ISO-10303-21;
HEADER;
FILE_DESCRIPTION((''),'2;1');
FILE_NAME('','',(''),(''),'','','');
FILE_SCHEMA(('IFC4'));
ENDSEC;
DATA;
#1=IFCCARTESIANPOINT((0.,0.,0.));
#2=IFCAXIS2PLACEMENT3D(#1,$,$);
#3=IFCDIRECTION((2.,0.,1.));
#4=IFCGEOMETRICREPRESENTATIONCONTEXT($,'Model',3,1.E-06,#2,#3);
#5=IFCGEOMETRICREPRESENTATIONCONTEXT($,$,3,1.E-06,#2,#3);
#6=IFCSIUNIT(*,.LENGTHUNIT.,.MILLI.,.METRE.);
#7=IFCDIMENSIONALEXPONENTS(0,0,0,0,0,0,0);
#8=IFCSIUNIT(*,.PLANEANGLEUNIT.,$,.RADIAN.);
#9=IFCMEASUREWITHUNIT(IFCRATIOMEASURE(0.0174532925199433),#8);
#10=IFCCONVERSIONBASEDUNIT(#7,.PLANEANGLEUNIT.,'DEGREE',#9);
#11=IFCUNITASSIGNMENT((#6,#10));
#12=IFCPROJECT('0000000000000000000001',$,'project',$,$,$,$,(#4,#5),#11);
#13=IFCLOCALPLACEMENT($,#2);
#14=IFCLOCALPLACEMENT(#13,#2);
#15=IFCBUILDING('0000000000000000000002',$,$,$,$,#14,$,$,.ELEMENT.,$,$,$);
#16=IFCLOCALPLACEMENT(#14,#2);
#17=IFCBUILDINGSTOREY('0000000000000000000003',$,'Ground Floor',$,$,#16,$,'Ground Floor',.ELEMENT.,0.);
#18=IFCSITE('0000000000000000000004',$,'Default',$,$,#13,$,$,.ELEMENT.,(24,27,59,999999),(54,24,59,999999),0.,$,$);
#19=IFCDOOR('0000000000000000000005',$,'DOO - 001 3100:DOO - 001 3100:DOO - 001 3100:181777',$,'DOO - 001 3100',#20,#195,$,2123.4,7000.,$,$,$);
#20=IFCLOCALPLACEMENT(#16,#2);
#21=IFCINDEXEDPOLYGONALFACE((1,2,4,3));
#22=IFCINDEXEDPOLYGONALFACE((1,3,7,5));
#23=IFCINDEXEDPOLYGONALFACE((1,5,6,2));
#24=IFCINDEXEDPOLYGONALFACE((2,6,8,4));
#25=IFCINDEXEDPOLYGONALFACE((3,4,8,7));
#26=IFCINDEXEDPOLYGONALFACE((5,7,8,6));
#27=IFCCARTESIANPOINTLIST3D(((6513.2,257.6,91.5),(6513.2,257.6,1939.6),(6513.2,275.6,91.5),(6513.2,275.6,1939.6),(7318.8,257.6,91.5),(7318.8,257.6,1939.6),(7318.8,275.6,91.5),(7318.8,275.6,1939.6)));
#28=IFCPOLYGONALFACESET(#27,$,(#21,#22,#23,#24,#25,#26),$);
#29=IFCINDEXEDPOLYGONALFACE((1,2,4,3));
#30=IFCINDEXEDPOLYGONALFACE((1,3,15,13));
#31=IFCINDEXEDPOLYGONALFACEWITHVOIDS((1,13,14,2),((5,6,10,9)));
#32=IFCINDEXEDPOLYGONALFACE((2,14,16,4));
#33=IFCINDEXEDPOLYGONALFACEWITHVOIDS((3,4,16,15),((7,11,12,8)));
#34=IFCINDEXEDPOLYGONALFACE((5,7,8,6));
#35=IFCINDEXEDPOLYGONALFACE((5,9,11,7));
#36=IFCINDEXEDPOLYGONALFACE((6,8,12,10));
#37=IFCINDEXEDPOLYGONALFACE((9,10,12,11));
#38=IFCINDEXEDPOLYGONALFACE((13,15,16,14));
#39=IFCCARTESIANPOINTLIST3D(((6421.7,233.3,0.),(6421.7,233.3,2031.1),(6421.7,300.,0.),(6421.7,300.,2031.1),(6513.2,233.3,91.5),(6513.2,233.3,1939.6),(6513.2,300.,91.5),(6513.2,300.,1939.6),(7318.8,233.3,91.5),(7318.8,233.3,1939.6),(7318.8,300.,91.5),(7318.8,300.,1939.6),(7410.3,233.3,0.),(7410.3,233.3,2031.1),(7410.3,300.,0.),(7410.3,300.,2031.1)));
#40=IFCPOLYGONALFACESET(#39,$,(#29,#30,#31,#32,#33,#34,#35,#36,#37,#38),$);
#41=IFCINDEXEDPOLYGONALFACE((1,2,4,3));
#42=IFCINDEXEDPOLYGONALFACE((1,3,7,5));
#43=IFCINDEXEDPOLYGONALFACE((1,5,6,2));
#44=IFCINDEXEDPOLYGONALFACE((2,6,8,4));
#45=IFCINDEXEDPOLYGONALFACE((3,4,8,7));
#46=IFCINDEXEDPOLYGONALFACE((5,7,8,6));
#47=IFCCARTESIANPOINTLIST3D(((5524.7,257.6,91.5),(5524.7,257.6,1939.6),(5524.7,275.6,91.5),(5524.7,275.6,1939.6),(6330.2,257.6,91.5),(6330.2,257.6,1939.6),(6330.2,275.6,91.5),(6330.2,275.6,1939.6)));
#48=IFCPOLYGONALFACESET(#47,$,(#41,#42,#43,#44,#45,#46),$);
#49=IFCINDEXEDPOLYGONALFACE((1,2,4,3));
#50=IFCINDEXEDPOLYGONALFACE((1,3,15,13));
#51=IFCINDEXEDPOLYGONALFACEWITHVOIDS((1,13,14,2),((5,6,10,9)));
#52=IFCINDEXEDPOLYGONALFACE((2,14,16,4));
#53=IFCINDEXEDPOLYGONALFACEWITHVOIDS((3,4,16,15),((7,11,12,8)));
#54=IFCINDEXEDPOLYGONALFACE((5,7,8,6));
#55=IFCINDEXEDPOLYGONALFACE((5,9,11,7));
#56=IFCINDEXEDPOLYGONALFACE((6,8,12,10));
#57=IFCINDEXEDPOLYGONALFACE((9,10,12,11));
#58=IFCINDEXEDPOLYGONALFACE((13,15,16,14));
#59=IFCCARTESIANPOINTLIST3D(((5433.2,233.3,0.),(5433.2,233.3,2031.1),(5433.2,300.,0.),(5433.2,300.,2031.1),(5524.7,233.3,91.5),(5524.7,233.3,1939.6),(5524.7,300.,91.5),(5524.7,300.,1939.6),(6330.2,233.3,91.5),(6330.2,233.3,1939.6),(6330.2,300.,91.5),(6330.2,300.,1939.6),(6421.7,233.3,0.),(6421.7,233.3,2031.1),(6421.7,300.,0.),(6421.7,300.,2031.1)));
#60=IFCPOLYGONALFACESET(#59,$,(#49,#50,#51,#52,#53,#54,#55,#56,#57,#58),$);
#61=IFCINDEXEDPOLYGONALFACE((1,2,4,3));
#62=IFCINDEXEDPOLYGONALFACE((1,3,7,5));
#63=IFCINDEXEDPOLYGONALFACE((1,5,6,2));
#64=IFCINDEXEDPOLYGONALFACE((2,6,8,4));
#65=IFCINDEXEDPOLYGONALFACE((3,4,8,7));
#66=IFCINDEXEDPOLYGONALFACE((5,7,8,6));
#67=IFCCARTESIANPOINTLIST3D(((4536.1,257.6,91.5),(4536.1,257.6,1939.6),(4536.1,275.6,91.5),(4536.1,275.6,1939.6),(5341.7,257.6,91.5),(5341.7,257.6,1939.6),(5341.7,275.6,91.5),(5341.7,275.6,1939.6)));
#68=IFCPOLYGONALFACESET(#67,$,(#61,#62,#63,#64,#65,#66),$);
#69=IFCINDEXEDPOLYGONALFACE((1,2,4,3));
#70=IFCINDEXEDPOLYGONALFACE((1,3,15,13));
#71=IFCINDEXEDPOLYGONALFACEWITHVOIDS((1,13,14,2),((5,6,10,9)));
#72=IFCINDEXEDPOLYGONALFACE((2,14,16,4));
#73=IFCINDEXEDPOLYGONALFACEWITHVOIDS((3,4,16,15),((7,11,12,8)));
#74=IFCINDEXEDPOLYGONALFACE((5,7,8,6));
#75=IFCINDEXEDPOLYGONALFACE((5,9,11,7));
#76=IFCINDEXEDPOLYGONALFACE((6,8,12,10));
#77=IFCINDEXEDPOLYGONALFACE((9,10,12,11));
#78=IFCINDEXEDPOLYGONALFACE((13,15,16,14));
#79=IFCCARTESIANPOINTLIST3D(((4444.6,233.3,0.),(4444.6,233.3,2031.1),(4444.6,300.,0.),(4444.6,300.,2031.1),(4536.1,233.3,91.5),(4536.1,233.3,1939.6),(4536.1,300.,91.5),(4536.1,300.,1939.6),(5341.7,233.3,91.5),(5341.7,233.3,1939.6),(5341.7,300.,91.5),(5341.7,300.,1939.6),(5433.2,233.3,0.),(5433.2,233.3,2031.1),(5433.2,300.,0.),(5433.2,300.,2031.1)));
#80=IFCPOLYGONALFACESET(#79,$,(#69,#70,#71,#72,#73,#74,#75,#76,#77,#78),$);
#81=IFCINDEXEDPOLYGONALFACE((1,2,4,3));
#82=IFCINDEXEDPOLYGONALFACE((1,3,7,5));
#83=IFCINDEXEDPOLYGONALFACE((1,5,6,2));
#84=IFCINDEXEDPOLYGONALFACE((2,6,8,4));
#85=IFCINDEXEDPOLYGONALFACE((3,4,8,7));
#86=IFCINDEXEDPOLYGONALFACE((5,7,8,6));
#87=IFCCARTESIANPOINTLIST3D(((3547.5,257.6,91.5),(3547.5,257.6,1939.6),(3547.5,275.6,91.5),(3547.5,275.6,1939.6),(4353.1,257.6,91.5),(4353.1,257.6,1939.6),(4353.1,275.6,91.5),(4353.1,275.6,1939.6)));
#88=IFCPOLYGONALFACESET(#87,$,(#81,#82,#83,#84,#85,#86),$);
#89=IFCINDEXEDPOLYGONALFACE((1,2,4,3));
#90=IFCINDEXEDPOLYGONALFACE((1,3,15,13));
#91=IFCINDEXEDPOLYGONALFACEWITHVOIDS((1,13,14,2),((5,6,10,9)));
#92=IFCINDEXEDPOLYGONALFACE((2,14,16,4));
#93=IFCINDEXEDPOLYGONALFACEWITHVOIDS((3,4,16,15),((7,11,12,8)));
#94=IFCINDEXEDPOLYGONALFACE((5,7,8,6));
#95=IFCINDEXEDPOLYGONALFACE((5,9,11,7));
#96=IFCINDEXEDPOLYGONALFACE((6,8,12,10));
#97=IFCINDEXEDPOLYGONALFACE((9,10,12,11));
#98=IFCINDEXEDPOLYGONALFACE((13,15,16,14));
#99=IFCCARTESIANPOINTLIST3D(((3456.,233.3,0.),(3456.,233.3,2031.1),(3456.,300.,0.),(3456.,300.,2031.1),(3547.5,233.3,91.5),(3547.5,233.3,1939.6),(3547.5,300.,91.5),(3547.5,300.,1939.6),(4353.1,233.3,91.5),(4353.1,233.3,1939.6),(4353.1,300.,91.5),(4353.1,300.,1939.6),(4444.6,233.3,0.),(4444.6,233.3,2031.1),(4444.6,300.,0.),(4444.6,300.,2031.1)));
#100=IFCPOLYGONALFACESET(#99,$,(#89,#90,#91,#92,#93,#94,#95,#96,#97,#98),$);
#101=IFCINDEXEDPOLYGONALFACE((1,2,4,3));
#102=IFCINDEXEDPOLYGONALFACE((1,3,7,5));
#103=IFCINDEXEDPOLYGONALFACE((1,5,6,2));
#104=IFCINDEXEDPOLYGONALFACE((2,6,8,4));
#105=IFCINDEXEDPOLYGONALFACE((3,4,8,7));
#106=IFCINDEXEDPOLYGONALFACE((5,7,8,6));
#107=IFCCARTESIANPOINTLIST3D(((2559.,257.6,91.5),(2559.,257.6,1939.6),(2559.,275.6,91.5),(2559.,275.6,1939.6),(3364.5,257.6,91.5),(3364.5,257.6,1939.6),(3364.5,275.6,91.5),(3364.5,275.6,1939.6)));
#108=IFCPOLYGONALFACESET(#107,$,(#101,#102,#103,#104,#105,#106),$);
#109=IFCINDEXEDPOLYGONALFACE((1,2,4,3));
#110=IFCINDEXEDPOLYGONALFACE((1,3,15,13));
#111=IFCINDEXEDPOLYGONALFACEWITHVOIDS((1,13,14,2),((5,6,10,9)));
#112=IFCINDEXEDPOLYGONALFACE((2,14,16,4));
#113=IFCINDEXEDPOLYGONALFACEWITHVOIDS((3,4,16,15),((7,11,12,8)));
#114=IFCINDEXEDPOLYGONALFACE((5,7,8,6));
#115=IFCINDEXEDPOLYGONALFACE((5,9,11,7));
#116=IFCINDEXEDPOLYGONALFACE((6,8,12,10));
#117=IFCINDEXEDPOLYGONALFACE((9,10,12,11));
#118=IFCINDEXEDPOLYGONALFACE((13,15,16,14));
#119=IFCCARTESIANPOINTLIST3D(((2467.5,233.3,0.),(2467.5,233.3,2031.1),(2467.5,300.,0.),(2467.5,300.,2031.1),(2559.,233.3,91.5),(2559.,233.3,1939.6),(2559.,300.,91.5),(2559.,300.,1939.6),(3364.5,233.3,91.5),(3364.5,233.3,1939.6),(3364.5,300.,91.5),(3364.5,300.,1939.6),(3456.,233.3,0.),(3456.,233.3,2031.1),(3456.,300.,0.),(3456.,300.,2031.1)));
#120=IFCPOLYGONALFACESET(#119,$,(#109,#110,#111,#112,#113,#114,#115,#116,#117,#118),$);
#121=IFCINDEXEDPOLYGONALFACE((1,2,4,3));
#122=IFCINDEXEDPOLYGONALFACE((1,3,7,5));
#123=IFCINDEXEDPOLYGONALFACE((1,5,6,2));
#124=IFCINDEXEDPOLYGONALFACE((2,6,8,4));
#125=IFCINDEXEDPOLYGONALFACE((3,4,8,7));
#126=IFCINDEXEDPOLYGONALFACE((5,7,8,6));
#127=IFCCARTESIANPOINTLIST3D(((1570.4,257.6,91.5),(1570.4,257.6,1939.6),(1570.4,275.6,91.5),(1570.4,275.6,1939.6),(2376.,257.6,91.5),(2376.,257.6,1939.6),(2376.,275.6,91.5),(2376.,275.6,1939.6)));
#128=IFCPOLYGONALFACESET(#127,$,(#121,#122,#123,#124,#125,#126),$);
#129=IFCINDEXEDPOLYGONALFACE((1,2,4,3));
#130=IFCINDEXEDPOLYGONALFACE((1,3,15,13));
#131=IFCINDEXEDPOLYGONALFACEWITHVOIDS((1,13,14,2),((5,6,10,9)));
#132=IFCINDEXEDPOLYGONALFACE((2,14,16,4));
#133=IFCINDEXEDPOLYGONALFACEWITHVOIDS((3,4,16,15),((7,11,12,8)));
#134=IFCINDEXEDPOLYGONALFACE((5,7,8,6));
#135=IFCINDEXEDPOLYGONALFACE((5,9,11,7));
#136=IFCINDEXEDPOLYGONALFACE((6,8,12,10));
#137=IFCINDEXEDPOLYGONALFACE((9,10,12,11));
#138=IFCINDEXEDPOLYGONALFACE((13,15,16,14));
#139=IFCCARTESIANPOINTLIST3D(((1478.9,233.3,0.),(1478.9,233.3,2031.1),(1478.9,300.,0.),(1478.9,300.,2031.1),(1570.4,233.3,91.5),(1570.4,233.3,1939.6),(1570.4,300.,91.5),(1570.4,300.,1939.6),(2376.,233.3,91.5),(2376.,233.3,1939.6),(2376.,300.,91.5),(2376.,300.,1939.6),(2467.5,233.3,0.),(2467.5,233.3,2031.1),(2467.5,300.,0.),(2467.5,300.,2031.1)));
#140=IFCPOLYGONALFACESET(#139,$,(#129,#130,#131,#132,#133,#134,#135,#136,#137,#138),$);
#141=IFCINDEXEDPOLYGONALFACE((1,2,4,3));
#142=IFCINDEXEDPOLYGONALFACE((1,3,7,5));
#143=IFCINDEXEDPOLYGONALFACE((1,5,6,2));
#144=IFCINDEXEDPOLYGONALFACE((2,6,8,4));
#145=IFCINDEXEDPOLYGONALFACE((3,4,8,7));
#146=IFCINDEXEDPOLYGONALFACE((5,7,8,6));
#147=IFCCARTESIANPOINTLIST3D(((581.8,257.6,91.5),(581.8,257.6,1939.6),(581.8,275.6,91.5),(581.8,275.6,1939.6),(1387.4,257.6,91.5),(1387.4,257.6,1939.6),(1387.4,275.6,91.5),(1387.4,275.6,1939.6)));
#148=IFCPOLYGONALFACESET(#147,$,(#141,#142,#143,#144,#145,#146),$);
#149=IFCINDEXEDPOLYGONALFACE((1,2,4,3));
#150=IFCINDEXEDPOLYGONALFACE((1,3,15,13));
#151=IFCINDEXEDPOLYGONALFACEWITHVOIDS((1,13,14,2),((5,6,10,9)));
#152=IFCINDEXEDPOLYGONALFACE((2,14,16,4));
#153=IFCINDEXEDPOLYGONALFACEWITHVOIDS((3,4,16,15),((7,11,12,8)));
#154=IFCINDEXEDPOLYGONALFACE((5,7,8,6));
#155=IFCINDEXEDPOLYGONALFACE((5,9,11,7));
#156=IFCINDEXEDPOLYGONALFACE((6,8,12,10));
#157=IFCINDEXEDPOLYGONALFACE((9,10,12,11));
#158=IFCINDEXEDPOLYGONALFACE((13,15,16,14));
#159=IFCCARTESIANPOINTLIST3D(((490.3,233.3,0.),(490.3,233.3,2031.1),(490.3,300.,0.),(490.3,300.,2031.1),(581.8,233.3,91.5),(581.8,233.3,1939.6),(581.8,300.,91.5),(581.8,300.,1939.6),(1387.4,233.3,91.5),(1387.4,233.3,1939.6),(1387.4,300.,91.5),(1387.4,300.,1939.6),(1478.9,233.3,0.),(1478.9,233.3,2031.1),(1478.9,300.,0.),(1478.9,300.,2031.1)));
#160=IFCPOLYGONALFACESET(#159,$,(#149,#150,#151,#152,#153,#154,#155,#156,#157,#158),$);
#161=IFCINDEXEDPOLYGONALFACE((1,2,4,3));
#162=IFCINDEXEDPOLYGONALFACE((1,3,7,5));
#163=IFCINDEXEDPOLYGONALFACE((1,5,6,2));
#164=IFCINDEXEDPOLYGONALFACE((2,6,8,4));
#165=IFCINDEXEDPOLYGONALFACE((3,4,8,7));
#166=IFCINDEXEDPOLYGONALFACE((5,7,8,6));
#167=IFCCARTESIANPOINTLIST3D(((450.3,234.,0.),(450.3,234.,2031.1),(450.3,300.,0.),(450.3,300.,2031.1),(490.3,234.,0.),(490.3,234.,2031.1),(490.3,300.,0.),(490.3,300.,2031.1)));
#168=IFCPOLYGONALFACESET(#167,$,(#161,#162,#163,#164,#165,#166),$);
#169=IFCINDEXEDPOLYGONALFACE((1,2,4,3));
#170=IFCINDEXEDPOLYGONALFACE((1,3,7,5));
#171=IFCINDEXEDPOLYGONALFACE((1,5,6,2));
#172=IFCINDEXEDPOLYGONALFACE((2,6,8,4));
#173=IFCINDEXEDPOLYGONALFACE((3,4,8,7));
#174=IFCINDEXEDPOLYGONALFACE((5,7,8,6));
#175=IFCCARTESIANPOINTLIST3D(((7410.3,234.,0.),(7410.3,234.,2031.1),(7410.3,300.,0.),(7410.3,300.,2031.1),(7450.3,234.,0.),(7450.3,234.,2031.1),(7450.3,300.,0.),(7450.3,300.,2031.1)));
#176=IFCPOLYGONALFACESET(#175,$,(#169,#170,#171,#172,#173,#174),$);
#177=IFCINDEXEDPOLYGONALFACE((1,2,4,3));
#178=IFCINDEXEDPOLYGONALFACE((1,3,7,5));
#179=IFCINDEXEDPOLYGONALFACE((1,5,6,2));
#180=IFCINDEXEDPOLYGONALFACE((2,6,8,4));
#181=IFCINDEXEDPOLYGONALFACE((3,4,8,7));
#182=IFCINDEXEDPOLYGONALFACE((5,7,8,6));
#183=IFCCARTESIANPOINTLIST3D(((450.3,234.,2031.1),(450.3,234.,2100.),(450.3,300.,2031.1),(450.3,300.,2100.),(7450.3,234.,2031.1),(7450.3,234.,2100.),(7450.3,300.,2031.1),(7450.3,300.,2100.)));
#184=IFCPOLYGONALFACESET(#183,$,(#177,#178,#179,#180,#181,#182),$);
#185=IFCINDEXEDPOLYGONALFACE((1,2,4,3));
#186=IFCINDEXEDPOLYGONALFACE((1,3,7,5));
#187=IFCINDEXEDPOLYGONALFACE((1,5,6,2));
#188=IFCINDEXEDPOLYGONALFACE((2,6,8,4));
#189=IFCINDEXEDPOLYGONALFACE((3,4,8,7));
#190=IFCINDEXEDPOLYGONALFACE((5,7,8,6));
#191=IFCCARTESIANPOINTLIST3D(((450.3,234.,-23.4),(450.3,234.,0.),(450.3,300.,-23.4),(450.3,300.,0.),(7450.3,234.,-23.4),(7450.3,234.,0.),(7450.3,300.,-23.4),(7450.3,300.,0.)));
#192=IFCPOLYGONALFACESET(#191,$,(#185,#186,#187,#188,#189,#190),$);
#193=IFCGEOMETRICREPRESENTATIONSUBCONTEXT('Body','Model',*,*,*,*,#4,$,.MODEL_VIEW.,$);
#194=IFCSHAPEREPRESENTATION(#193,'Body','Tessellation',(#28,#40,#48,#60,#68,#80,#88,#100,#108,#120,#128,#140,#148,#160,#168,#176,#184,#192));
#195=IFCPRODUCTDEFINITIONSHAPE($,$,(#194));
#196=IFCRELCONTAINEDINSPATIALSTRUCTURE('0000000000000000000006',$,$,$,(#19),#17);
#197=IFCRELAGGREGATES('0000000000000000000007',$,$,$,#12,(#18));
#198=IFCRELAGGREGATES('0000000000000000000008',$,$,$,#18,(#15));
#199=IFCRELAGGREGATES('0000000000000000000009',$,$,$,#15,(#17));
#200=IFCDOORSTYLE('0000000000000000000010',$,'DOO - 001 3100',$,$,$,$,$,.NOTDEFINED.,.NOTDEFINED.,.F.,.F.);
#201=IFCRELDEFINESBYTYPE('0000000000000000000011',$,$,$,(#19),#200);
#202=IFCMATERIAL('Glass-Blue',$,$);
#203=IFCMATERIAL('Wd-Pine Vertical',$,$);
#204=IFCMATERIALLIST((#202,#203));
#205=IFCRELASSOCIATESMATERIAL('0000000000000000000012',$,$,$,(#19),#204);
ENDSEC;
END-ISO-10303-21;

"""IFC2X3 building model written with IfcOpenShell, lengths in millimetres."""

from ifc_helpers import new_model, entity, si_unit, converted_unit, direction, frame, frame_2d, origin, origin_2d_with_axis, place, context, subcontext, project, spatial, polyline, rectangle, outline, extrude, source, transform, mapped, material, material_list, type_object, type_shapes, element, save


model = new_model("IFC2X3")

# Units and contexts
model_context = context("Model", 3, precision=1e-06, world=origin(), true_north=direction((2.0, 0.0, 1.0)))
context_of_model = context(None, 3, precision=1e-06, world=origin(), true_north=direction((2.0, 0.0, 1.0)))
body_context = subcontext(model_context, "Body", "Model", "MODEL_VIEW")
ifc_project = project(units=[si_unit("LENGTHUNIT", "METRE", prefix="MILLI"), converted_unit("PLANEANGLEUNIT", "DEGREE", entity("IfcRatioMeasure", 0.0174532925199433), si_unit("PLANEANGLEUNIT", "RADIAN"), dimensions=[0, 0, 0, 0, 0, 0, 0])], contexts=[model_context, context_of_model])

# Site, building, storey
site_placement = place(None, origin())
site = spatial("IfcSite", under=ifc_project, at=site_placement, Name="Default", CompositionType="ELEMENT", RefLatitude=(24, 27, 59, 999999), RefLongitude=(54, 24, 59, 999999), RefElevation=0.0)
building_placement = place(site_placement, origin())
building = spatial("IfcBuilding", under=site, at=building_placement, CompositionType="ELEMENT")
storey_placement = place(building_placement, origin())
storey = spatial("IfcBuildingStorey", under=building, at=storey_placement, Name="Ground Floor", LongName="Ground Floor", CompositionType="ELEMENT", Elevation=0.0)

# Door
ifc_material_1 = material(Name="Glass-Blue")
ifc_material_2 = material(Name="Wd-Pine Vertical")
ifc_material_list = material_list([ifc_material_1, ifc_material_2])
door_style = type_object("IfcDoorStyle", Name="DOO - 001 3100", ConstructionType="NOTDEFINED", OperationType="NOTDEFINED", ParameterTakesPrecedence=False, Sizeable=False)
shared_shape = source(origin(), body_context, "Body", "SweptSolid", [
    extrude(rectangle(XDim=805.6, YDim=18.0, at=frame_2d((0.0, 0.0), x_axis=(1.0, 0.0))), frame((6916.0, 266.6, 91.5), z_axis=(0.0, 0.0, 1.0), x_axis=(-1.0, 0.0, 0.0)), (0.0, 0.0, 1.0), 1848.1),
    extrude(outline(polyline([(-494.3, -1015.5), (494.3, -1015.5), (494.3, 1015.5), (-494.3, 1015.5), (-494.3, -1015.5)]), holes=[polyline([(402.8, 924.0), (402.8, -924.0), (-402.8, -924.0), (-402.8, 924.0), (402.8, 924.0)])]), frame((6916.0, 233.3, 1015.5), z_axis=(0.0, 1.0, 0.0), x_axis=(-1.0, 0.0, 0.0)), (0.0, 0.0, 1.0), 66.7),
    extrude(rectangle(XDim=805.6, YDim=18.0, at=frame_2d((0.0, 0.0), x_axis=(1.0, 0.0))), frame((5927.5, 266.6, 91.5), z_axis=(0.0, 0.0, 1.0), x_axis=(-1.0, 0.0, 0.0)), (0.0, 0.0, 1.0), 1848.1),
    extrude(outline(polyline([(-494.3, -1015.5), (494.3, -1015.5), (494.3, 1015.5), (-494.3, 1015.5), (-494.3, -1015.5)]), holes=[polyline([(402.8, 924.0), (402.8, -924.0), (-402.8, -924.0), (-402.8, 924.0), (402.8, 924.0)])]), frame((5927.5, 233.3, 1015.5), z_axis=(0.0, 1.0, 0.0), x_axis=(-1.0, 0.0, 0.0)), (0.0, 0.0, 1.0), 66.7),
    extrude(rectangle(XDim=805.6, YDim=18.0, at=frame_2d((0.0, 0.0), x_axis=(1.0, 0.0))), frame((4938.9, 266.6, 91.5), z_axis=(0.0, 0.0, 1.0), x_axis=(-1.0, 0.0, 0.0)), (0.0, 0.0, 1.0), 1848.1),
    extrude(outline(polyline([(-494.3, -1015.5), (494.3, -1015.5), (494.3, 1015.5), (-494.3, 1015.5), (-494.3, -1015.5)]), holes=[polyline([(402.8, 924.0), (402.8, -924.0), (-402.8, -924.0), (-402.8, 924.0), (402.8, 924.0)])]), frame((4938.9, 233.3, 1015.5), z_axis=(0.0, 1.0, 0.0), x_axis=(-1.0, 0.0, 0.0)), (0.0, 0.0, 1.0), 66.7),
    extrude(rectangle(XDim=805.6, YDim=18.0, at=frame_2d((0.0, 0.0), x_axis=(1.0, 0.0))), frame((3950.3, 266.6, 91.5), z_axis=(0.0, 0.0, 1.0), x_axis=(-1.0, 0.0, 0.0)), (0.0, 0.0, 1.0), 1848.1),
    extrude(outline(polyline([(-494.3, -1015.5), (494.3, -1015.5), (494.3, 1015.5), (-494.3, 1015.5), (-494.3, -1015.5)]), holes=[polyline([(402.8, 924.0), (402.8, -924.0), (-402.8, -924.0), (-402.8, 924.0), (402.8, 924.0)])]), frame((3950.3, 233.3, 1015.5), z_axis=(0.0, 1.0, 0.0), x_axis=(-1.0, 0.0, 0.0)), (0.0, 0.0, 1.0), 66.7),
    extrude(rectangle(XDim=805.6, YDim=18.0, at=frame_2d((0.0, 0.0), x_axis=(1.0, 0.0))), frame((2961.7, 266.6, 91.5), z_axis=(0.0, 0.0, 1.0), x_axis=(-1.0, 0.0, 0.0)), (0.0, 0.0, 1.0), 1848.1),
    extrude(outline(polyline([(-494.3, -1015.5), (494.3, -1015.5), (494.3, 1015.5), (-494.3, 1015.5), (-494.3, -1015.5)]), holes=[polyline([(402.8, 924.0), (402.8, -924.0), (-402.8, -924.0), (-402.8, 924.0), (402.8, 924.0)])]), frame((2961.7, 233.3, 1015.5), z_axis=(0.0, 1.0, 0.0), x_axis=(-1.0, 0.0, 0.0)), (0.0, 0.0, 1.0), 66.7),
    extrude(rectangle(XDim=805.6, YDim=18.0, at=frame_2d((0.0, 0.0), x_axis=(1.0, 0.0))), frame((1973.2, 266.6, 91.5), z_axis=(0.0, 0.0, 1.0), x_axis=(-1.0, 0.0, 0.0)), (0.0, 0.0, 1.0), 1848.1),
    extrude(outline(polyline([(-494.3, -1015.5), (494.3, -1015.5), (494.3, 1015.5), (-494.3, 1015.5), (-494.3, -1015.5)]), holes=[polyline([(402.8, 924.0), (402.8, -924.0), (-402.8, -924.0), (-402.8, 924.0), (402.8, 924.0)])]), frame((1973.2, 233.3, 1015.5), z_axis=(0.0, 1.0, 0.0), x_axis=(-1.0, 0.0, 0.0)), (0.0, 0.0, 1.0), 66.7),
    extrude(rectangle(XDim=805.6, YDim=18.0, at=frame_2d((0.0, 0.0), x_axis=(1.0, 0.0))), frame((984.6, 266.6, 91.5), z_axis=(0.0, 0.0, 1.0), x_axis=(-1.0, 0.0, 0.0)), (0.0, 0.0, 1.0), 1848.1),
    extrude(outline(polyline([(-494.3, -1015.5), (494.3, -1015.5), (494.3, 1015.5), (-494.3, 1015.5), (-494.3, -1015.5)]), holes=[polyline([(402.8, 924.0), (402.8, -924.0), (-402.8, -924.0), (-402.8, 924.0), (402.8, 924.0)])]), frame((984.6, 233.3, 1015.5), z_axis=(0.0, 1.0, 0.0), x_axis=(-1.0, 0.0, 0.0)), (0.0, 0.0, 1.0), 66.7),
    extrude(rectangle(XDim=40.0, YDim=66.0, at=frame_2d((0.0, 0.0), x_axis=(1.0, 0.0))), frame((470.3, 267.0, 0.0), z_axis=(0.0, 0.0, 1.0), x_axis=(-1.0, 0.0, 0.0)), (0.0, 0.0, 1.0), 2031.1),
    extrude(rectangle(XDim=40.0, YDim=66.0, at=origin_2d_with_axis()), frame((7430.3, 267.0, 0.0), z_axis=(0.0, 0.0, 1.0), x_axis=(-1.0, 0.0, 0.0)), (0.0, 0.0, 1.0), 2031.1),
    extrude(rectangle(XDim=7000.0, YDim=66.0, at=origin_2d_with_axis()), frame((3950.3, 267.0, 2031.1), z_axis=(0.0, 0.0, 1.0), x_axis=(-1.0, 0.0, 0.0)), (0.0, 0.0, 1.0), 68.9),
    extrude(rectangle(XDim=7000.0, YDim=66.0, at=origin_2d_with_axis()), frame((3950.3, 267.0, -23.4), z_axis=(0.0, 0.0, 1.0), x_axis=(-1.0, 0.0, 0.0)), (0.0, 0.0, 1.0), 23.4),
])
type_shapes(door_style, [shared_shape])
door_placement = place(storey_placement, origin())
element("IfcDoor", 1, at=door_placement, inside=storey, type_object=door_style, material=ifc_material_list, Name="DOO - 001 3100:DOO - 001 3100:DOO - 001 3100:181777", ObjectType="DOO - 001 3100", OverallHeight=2123.4, OverallWidth=7000.0, context=body_context, shape_type="MappedRepresentation", body=[
    mapped(shared_shape, transform((0.0, 0.0, 0.0), scale=1.0)),
])

save(model, "model.ifc")
